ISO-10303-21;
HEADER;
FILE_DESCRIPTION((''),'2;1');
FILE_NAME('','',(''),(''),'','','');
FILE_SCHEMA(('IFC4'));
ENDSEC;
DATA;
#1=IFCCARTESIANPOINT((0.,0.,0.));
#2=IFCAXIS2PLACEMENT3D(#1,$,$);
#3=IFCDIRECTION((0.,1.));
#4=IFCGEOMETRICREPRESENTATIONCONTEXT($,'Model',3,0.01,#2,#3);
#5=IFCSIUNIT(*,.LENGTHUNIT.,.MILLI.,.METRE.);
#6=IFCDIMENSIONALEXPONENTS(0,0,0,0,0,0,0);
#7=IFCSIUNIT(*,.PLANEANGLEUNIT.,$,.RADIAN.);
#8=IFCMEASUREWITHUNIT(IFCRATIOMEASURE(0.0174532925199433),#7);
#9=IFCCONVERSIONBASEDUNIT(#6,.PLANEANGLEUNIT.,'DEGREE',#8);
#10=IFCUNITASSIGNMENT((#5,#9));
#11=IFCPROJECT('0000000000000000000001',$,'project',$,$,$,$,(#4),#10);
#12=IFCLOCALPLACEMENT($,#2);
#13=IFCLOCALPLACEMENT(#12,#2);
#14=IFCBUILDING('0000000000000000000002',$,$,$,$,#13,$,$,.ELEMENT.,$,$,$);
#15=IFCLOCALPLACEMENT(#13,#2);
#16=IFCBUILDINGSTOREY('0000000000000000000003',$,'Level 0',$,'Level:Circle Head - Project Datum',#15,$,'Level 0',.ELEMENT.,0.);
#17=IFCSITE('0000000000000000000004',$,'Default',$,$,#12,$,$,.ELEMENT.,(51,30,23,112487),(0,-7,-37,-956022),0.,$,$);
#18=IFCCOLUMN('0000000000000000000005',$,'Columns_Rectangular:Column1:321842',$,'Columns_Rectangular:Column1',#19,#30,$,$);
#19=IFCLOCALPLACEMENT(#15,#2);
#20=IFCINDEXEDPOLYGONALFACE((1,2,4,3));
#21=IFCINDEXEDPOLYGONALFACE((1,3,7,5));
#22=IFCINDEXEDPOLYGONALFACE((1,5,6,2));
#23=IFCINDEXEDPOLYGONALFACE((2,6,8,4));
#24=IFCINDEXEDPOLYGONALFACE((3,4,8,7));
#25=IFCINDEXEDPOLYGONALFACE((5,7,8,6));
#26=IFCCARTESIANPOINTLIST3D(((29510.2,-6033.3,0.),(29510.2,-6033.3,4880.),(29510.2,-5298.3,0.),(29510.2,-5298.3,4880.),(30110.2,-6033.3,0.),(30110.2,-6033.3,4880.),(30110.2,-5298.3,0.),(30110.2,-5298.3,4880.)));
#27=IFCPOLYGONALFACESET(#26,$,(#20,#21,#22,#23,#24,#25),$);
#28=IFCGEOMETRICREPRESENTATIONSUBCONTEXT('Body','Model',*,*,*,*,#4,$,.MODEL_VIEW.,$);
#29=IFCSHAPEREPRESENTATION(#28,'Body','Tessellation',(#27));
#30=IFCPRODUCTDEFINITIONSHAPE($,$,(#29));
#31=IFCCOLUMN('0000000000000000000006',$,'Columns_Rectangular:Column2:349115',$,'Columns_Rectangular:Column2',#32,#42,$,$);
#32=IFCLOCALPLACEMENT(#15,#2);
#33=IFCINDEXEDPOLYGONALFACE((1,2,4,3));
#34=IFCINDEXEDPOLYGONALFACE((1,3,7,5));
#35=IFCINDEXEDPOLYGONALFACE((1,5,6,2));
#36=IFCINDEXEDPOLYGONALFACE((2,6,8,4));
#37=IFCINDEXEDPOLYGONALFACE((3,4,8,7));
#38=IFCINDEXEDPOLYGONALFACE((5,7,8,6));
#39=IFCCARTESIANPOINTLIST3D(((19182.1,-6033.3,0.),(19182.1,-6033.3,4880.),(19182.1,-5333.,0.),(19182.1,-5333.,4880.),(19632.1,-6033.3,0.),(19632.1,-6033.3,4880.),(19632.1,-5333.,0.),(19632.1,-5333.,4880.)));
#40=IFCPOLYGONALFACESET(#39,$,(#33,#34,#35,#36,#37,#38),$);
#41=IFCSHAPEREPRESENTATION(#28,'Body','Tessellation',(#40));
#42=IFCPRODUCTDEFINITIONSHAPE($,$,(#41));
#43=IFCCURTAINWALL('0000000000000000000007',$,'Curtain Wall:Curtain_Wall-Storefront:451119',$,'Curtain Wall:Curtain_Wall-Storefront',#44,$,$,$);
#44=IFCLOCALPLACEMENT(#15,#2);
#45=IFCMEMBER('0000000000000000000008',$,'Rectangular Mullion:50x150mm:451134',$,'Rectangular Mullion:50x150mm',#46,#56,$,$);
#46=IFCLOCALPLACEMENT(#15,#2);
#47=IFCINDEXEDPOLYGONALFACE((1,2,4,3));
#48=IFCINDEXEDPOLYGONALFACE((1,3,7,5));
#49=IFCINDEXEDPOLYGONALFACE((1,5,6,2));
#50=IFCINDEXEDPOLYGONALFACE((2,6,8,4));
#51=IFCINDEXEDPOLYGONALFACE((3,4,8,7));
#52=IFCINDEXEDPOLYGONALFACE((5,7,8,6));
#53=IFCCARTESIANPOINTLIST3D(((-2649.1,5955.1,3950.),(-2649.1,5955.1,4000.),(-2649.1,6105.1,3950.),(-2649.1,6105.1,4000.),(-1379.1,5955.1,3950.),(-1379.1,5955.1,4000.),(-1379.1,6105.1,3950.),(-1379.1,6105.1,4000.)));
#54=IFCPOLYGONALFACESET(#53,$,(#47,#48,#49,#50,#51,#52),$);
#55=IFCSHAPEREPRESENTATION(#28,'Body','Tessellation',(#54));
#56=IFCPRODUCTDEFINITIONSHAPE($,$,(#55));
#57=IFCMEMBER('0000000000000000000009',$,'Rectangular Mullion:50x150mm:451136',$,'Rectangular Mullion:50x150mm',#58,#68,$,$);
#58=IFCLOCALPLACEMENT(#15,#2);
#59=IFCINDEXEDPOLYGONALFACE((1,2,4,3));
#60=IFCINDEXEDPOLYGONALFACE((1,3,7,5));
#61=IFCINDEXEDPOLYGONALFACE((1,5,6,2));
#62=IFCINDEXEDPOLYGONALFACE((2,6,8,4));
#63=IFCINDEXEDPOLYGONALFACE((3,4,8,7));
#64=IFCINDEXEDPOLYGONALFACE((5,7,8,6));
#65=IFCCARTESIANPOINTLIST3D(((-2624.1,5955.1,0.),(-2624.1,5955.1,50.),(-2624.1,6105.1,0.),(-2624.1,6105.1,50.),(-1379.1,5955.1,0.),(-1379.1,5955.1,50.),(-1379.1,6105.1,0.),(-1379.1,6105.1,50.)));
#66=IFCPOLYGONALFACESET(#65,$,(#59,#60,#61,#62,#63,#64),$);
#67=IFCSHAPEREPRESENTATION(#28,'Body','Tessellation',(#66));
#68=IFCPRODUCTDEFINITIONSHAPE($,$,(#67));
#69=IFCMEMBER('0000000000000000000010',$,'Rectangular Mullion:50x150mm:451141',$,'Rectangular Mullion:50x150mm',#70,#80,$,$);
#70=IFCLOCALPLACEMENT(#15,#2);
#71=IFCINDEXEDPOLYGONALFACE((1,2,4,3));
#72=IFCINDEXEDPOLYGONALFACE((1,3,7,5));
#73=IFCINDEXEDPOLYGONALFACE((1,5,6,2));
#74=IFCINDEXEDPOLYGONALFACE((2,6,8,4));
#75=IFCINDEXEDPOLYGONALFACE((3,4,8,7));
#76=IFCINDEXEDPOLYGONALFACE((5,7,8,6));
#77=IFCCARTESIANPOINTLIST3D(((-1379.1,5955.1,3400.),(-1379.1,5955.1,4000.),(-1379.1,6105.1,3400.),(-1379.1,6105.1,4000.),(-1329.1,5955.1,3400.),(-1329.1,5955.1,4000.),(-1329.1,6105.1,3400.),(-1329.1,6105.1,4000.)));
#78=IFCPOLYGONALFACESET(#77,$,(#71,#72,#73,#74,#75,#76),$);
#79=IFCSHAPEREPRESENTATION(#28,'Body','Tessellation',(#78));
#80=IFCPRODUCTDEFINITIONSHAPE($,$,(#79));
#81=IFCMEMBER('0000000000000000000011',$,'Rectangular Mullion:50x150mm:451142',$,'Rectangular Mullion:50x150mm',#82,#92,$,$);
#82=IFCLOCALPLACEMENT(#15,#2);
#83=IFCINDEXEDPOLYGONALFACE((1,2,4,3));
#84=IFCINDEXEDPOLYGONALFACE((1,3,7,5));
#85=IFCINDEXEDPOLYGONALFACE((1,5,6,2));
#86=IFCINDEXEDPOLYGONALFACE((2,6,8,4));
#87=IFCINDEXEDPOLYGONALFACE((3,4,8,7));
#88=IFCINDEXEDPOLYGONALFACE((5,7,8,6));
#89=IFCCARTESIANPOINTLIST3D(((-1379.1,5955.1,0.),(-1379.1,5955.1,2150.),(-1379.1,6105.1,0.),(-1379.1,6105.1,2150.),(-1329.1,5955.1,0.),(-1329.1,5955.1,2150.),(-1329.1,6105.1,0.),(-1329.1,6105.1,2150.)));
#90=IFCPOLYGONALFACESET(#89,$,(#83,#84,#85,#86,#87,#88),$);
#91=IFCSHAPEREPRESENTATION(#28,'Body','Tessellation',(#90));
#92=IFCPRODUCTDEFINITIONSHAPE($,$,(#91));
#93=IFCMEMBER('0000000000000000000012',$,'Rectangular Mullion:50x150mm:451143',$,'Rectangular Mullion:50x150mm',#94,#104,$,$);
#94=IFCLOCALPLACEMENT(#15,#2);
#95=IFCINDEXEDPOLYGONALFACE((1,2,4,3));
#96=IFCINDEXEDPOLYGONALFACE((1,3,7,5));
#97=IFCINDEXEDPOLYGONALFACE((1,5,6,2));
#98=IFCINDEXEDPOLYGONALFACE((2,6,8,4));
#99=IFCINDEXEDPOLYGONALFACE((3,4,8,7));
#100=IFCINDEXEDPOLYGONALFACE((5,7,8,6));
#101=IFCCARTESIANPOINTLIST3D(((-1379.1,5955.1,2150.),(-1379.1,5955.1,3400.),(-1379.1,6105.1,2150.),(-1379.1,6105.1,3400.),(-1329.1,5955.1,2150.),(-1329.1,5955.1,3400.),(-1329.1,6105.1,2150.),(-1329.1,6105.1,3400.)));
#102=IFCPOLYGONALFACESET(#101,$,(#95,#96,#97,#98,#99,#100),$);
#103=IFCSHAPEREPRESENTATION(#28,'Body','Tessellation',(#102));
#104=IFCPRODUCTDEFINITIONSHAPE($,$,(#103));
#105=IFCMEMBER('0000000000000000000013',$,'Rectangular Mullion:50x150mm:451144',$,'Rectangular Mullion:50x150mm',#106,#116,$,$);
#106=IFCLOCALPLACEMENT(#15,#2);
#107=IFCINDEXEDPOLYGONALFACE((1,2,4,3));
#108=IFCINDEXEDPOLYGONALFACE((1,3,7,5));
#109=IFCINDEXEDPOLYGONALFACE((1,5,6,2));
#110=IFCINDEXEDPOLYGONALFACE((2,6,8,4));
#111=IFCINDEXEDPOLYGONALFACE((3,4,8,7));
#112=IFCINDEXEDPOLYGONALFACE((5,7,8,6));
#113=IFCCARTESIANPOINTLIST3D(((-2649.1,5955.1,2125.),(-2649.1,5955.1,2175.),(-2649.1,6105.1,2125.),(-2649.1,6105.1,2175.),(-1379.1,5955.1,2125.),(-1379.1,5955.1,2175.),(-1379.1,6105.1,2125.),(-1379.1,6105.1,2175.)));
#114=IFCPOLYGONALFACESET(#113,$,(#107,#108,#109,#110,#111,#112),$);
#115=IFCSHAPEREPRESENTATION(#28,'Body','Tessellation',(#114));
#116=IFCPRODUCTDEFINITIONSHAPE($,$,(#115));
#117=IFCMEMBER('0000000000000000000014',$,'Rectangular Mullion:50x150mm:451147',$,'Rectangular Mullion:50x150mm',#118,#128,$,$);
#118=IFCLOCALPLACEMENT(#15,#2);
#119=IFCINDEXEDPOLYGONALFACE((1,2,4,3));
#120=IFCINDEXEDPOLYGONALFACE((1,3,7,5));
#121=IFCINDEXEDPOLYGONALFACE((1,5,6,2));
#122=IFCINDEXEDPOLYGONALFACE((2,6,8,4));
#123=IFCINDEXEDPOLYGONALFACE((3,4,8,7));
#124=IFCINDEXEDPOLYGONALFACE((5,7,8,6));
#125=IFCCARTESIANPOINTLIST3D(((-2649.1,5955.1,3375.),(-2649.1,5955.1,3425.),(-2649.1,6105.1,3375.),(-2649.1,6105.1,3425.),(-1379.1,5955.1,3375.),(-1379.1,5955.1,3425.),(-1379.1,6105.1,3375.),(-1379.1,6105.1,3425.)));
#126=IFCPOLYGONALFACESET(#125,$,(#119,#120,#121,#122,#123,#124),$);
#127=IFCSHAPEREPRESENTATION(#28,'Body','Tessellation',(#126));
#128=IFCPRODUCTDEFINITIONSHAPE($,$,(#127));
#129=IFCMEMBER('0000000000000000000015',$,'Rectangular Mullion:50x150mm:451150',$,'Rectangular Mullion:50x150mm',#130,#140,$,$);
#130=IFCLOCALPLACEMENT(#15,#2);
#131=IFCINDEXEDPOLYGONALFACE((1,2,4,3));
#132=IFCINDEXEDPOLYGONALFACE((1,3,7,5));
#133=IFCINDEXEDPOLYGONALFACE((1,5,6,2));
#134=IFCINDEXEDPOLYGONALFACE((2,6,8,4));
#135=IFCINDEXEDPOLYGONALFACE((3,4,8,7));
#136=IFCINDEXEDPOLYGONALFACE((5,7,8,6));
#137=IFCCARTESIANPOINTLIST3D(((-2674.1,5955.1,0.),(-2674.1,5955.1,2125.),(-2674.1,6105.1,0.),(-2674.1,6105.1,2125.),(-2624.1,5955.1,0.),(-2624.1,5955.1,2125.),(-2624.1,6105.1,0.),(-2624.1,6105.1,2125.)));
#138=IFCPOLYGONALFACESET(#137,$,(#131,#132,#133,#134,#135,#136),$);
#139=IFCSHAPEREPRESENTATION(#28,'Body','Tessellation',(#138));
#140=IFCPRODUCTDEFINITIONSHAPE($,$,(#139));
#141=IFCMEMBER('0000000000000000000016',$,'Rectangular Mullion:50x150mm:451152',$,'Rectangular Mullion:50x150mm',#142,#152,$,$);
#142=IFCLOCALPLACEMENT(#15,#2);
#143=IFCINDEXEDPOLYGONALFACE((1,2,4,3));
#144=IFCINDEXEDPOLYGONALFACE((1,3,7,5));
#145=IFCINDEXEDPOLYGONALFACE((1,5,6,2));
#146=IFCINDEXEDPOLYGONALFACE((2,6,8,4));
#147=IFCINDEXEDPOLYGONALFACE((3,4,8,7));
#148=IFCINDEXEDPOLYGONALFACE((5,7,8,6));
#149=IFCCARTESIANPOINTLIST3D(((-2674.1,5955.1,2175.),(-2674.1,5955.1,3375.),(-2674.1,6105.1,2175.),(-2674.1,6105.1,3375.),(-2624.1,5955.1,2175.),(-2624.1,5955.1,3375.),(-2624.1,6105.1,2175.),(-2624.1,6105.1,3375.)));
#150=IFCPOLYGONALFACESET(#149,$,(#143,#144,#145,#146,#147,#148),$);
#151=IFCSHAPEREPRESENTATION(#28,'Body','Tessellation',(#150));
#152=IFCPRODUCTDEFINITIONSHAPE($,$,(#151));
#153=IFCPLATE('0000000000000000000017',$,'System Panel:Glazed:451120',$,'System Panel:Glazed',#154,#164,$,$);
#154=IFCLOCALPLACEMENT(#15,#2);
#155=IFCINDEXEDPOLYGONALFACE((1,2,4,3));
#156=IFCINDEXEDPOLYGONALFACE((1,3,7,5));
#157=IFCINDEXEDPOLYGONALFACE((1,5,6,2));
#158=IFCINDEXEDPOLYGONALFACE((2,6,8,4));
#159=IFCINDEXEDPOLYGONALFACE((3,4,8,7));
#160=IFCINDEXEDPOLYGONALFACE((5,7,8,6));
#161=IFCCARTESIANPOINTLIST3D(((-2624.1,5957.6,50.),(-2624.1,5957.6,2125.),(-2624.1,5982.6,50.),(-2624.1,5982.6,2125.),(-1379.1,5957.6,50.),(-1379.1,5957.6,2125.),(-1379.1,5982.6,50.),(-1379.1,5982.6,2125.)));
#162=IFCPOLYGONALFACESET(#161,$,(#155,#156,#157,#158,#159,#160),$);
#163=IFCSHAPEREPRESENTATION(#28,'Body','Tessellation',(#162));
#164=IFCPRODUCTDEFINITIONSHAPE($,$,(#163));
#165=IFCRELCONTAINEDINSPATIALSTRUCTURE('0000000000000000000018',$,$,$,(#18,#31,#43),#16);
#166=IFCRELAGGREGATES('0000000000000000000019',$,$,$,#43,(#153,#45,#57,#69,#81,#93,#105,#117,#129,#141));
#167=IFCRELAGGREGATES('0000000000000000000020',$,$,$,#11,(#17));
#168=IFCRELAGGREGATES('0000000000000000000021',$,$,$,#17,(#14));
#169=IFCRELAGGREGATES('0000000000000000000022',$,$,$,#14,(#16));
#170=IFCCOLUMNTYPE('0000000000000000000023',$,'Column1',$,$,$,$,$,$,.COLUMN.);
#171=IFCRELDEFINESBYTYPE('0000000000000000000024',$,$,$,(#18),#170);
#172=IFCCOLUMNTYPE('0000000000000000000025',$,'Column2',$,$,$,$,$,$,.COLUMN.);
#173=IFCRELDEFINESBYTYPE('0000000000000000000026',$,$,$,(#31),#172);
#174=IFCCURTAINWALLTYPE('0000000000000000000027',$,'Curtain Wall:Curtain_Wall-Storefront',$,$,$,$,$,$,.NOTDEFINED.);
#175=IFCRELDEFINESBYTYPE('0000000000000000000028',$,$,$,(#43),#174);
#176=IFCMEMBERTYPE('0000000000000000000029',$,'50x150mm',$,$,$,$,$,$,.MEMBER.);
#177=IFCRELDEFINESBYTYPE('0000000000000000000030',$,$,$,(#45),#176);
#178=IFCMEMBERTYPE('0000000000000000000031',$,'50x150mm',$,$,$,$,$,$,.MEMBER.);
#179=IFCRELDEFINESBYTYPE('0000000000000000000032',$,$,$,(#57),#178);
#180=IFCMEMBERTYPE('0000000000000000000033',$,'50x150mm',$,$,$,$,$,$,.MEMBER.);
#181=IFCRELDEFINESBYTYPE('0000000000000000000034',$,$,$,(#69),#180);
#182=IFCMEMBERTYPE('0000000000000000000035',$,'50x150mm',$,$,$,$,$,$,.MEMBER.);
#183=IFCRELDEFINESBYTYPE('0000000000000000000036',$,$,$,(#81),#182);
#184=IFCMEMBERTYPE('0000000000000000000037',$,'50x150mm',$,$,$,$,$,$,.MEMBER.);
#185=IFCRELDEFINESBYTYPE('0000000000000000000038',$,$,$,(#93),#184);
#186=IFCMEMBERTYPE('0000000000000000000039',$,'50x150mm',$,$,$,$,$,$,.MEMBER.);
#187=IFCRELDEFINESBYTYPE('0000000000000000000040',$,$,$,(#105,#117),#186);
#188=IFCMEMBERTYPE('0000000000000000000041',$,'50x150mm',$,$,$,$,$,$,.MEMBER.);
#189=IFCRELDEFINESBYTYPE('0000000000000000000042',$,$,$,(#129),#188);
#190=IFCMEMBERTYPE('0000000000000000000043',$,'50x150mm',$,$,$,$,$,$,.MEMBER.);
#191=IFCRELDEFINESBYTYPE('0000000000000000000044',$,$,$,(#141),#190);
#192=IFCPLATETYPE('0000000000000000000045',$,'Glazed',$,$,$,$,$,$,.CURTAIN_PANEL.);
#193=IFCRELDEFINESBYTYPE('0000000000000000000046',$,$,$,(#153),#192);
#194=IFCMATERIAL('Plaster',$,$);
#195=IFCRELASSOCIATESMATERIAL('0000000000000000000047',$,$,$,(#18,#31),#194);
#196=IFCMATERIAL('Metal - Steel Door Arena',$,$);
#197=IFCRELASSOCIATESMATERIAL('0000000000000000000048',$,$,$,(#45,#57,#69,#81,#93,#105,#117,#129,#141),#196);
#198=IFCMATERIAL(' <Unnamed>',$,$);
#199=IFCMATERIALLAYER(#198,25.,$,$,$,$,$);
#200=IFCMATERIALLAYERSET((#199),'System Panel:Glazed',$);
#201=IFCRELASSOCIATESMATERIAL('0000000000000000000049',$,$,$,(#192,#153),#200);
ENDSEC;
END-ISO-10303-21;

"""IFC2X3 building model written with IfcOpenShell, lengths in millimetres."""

from ifc_helpers import new_model, entity, si_unit, converted_unit, direction, frame, frame_2d, origin, origin_2d_with_axis, place, context, subcontext, project, spatial, rectangle, extrude, source, transform, mapped, material, layer, layer_set, layer_usage, type_object, type_shapes, element, aggregate, save


model = new_model("IFC2X3")

# Units and contexts
model_context = context("Model", 3, precision=0.01, world=origin(), true_north=direction((0.0, 1.0)))
body_context = subcontext(model_context, "Body", "Model", "MODEL_VIEW")
ifc_project = project(units=[si_unit("LENGTHUNIT", "METRE", prefix="MILLI"), converted_unit("PLANEANGLEUNIT", "DEGREE", entity("IfcRatioMeasure", 0.0174532925199433), si_unit("PLANEANGLEUNIT", "RADIAN"), dimensions=[0, 0, 0, 0, 0, 0, 0])], contexts=[model_context])

# Site, building, storey
site_placement = place(None, origin())
site = spatial("IfcSite", under=ifc_project, at=site_placement, Name="Default", CompositionType="ELEMENT", RefLatitude=(51, 30, 23, 112487), RefLongitude=(0, -7, -37, -956022), RefElevation=0.0)
building_placement = place(site_placement, origin())
building = spatial("IfcBuilding", under=site, at=building_placement, CompositionType="ELEMENT")
storey_placement = place(building_placement, origin())
storey = spatial("IfcBuildingStorey", under=building, at=storey_placement, Name="Level 0", ObjectType="Level:Circle Head - Project Datum", LongName="Level 0", CompositionType="ELEMENT", Elevation=0.0)

# Columns
ifc_material_1 = material(Name="Plaster")
column_type_1 = type_object("IfcColumnType", Name="Column1", PredefinedType="COLUMN")
shared_shape_1 = source(origin(), body_context, "Body", "SweptSolid", [
    extrude(rectangle(XDim=735.0, YDim=600.0, at=frame_2d((0.0, 0.0), x_axis=(1.0, 0.0))), frame((29810.2, -5665.8, 0.0), z_axis=(0.0, 0.0, 1.0), x_axis=(0.0, -1.0, 0.0)), (0.0, 0.0, 1.0), 4880.0),
])
type_shapes(column_type_1, [shared_shape_1])
column_1_placement = place(storey_placement, origin())
element("IfcColumn", 1, at=column_1_placement, inside=storey, type_object=column_type_1, material=ifc_material_1, Name="Columns_Rectangular:Column1:321842", ObjectType="Columns_Rectangular:Column1", context=body_context, shape_type="MappedRepresentation", body=[
    mapped(shared_shape_1, transform((0.0, 0.0, 0.0), scale=1.0)),
])
column_type_2 = type_object("IfcColumnType", Name="Column2", PredefinedType="COLUMN")
shared_shape_2 = source(origin(), body_context, "Body", "SweptSolid", [
    extrude(rectangle(XDim=700.3, YDim=450.0, at=frame_2d((0.0, 0.0), x_axis=(1.0, 0.0))), frame((19407.1, -5683.1, 0.0), z_axis=(0.0, 0.0, 1.0), x_axis=(0.0, -1.0, 0.0)), (0.0, 0.0, 1.0), 4880.0),
])
type_shapes(column_type_2, [shared_shape_2])
column_2_placement = place(storey_placement, origin())
element("IfcColumn", 2, at=column_2_placement, inside=storey, type_object=column_type_2, material=ifc_material_1, Name="Columns_Rectangular:Column2:349115", ObjectType="Columns_Rectangular:Column2", context=body_context, shape_type="MappedRepresentation", body=[
    mapped(shared_shape_2, transform((0.0, 0.0, 0.0), scale=1.0)),
])

# Curtain wall, members
curtain_wall_type = type_object("IfcCurtainWallType", Name="Curtain Wall:Curtain_Wall-Storefront", PredefinedType="NOTDEFINED")
curtain_wall_1_placement = place(storey_placement, origin())
curtain_wall_1 = element("IfcCurtainWall", 3, at=curtain_wall_1_placement, inside=storey, type_object=curtain_wall_type, Name="Curtain Wall:Curtain_Wall-Storefront:451119", ObjectType="Curtain Wall:Curtain_Wall-Storefront")
ifc_material_2 = material(Name="Metal - Steel Door Arena")
member_type_1 = type_object("IfcMemberType", Name="50x150mm", PredefinedType="MEMBER")
shared_shape_3 = source(origin(), body_context, "Body", "SweptSolid", [
    extrude(rectangle(XDim=150.0, YDim=50.0, at=origin_2d_with_axis()), frame((-25.0, 0.0, -1270.0), z_axis=(0.0, 0.0, 1.0), x_axis=(0.0, -1.0, 0.0)), (0.0, 0.0, 1.0), 1270.0),
])
type_shapes(member_type_1, [shared_shape_3])
member_1_placement = place(storey_placement, frame((-2649.1, 6030.1, 4000.0), z_axis=(-1.0, 0.0, 0.0), x_axis=(0.0, 0.0, 1.0)))
member_1 = element("IfcMember", 4, at=member_1_placement, type_object=member_type_1, material=ifc_material_2, Name="Rectangular Mullion:50x150mm:451134", ObjectType="Rectangular Mullion:50x150mm", context=body_context, shape_type="MappedRepresentation", body=[
    mapped(shared_shape_3, transform((0.0, 0.0, 0.0), scale=1.0)),
])
member_type_2 = type_object("IfcMemberType", Name="50x150mm", PredefinedType="MEMBER")
shared_shape_4 = source(origin(), body_context, "Body", "SweptSolid", [
    extrude(rectangle(XDim=150.0, YDim=50.0, at=origin_2d_with_axis()), frame((-25.0, 0.0, -1245.0), z_axis=(0.0, 0.0, 1.0), x_axis=(0.0, -1.0, 0.0)), (0.0, 0.0, 1.0), 1245.0),
])
type_shapes(member_type_2, [shared_shape_4])
member_2_placement = place(storey_placement, frame((-1379.1, 6030.1, 0.0), z_axis=(1.0, 0.0, 0.0), x_axis=(0.0, 0.0, -1.0)))
member_2 = element("IfcMember", 5, at=member_2_placement, type_object=member_type_2, material=ifc_material_2, Name="Rectangular Mullion:50x150mm:451136", ObjectType="Rectangular Mullion:50x150mm", context=body_context, shape_type="MappedRepresentation", body=[
    mapped(shared_shape_4, transform((0.0, 0.0, 0.0), scale=1.0)),
])
member_type_3 = type_object("IfcMemberType", Name="50x150mm", PredefinedType="MEMBER")
shared_shape_5 = source(origin(), body_context, "Body", "SweptSolid", [
    extrude(rectangle(XDim=150.0, YDim=50.0, at=origin_2d_with_axis()), frame((-25.0, 0.0, -600.0), z_axis=(0.0, 0.0, 1.0), x_axis=(0.0, -1.0, 0.0)), (0.0, 0.0, 1.0), 600.0),
])
type_shapes(member_type_3, [shared_shape_5])
member_3_placement = place(storey_placement, frame((-1329.1, 6030.1, 4000.0)))
member_3 = element("IfcMember", 6, at=member_3_placement, type_object=member_type_3, material=ifc_material_2, Name="Rectangular Mullion:50x150mm:451141", ObjectType="Rectangular Mullion:50x150mm", context=body_context, shape_type="MappedRepresentation", body=[
    mapped(shared_shape_5, transform((0.0, 0.0, 0.0), scale=1.0)),
])
member_type_4 = type_object("IfcMemberType", Name="50x150mm", PredefinedType="MEMBER")
shared_shape_6 = source(origin(), body_context, "Body", "SweptSolid", [
    extrude(rectangle(XDim=150.0, YDim=50.0, at=origin_2d_with_axis()), frame((-25.0, 0.0, -2150.0), z_axis=(0.0, 0.0, 1.0), x_axis=(0.0, -1.0, 0.0)), (0.0, 0.0, 1.0), 2150.0),
])
type_shapes(member_type_4, [shared_shape_6])
member_4_placement = place(storey_placement, frame((-1329.1, 6030.1, 2150.0)))
member_4 = element("IfcMember", 7, at=member_4_placement, type_object=member_type_4, material=ifc_material_2, Name="Rectangular Mullion:50x150mm:451142", ObjectType="Rectangular Mullion:50x150mm", context=body_context, shape_type="MappedRepresentation", body=[
    mapped(shared_shape_6, transform((0.0, 0.0, 0.0), scale=1.0)),
])
member_type_5 = type_object("IfcMemberType", Name="50x150mm", PredefinedType="MEMBER")
shared_shape_7 = source(origin(), body_context, "Body", "SweptSolid", [
    extrude(rectangle(XDim=150.0, YDim=50.0, at=origin_2d_with_axis()), frame((-25.0, 0.0, -1250.0), z_axis=(0.0, 0.0, 1.0), x_axis=(0.0, -1.0, 0.0)), (0.0, 0.0, 1.0), 1250.0),
])
type_shapes(member_type_5, [shared_shape_7])
member_5_placement = place(storey_placement, frame((-1329.1, 6030.1, 3400.0)))
member_5 = element("IfcMember", 8, at=member_5_placement, type_object=member_type_5, material=ifc_material_2, Name="Rectangular Mullion:50x150mm:451143", ObjectType="Rectangular Mullion:50x150mm", context=body_context, shape_type="MappedRepresentation", body=[
    mapped(shared_shape_7, transform((0.0, 0.0, 0.0), scale=1.0)),
])
member_type_6 = type_object("IfcMemberType", Name="50x150mm", PredefinedType="MEMBER")
shared_shape_8 = source(origin(), body_context, "Body", "SweptSolid", [
    extrude(rectangle(XDim=150.0, YDim=50.0, at=origin_2d_with_axis()), frame((0.0, 0.0, -1270.0), z_axis=(0.0, 0.0, 1.0), x_axis=(0.0, -1.0, 0.0)), (0.0, 0.0, 1.0), 1270.0),
])
type_shapes(member_type_6, [shared_shape_8])
member_6_placement = place(storey_placement, frame((-2649.1, 6030.1, 2150.0), z_axis=(-1.0, 0.0, 0.0), x_axis=(0.0, 0.0, 1.0)))
member_6 = element("IfcMember", 9, at=member_6_placement, type_object=member_type_6, material=ifc_material_2, Name="Rectangular Mullion:50x150mm:451144", ObjectType="Rectangular Mullion:50x150mm", context=body_context, shape_type="MappedRepresentation", body=[
    mapped(shared_shape_8, transform((0.0, 0.0, 0.0), scale=1.0)),
])
member_7_placement = place(storey_placement, frame((-2649.1, 6030.1, 3400.0), z_axis=(-1.0, 0.0, 0.0), x_axis=(0.0, 0.0, 1.0)))
member_7 = element("IfcMember", 10, at=member_7_placement, type_object=member_type_6, material=ifc_material_2, Name="Rectangular Mullion:50x150mm:451147", ObjectType="Rectangular Mullion:50x150mm", context=body_context, shape_type="MappedRepresentation", body=[
    mapped(shared_shape_8, transform((0.0, 0.0, 0.0), scale=1.0)),
])
member_type_7 = type_object("IfcMemberType", Name="50x150mm", PredefinedType="MEMBER")
shared_shape_9 = source(origin(), body_context, "Body", "SweptSolid", [
    extrude(rectangle(XDim=150.0, YDim=50.0, at=origin_2d_with_axis()), frame((0.0, 0.0, -2125.0), z_axis=(0.0, 0.0, 1.0), x_axis=(0.0, -1.0, 0.0)), (0.0, 0.0, 1.0), 2125.0),
])
type_shapes(member_type_7, [shared_shape_9])
member_8_placement = place(storey_placement, frame((-2649.1, 6030.1, 0.0), z_axis=(0.0, 0.0, -1.0), x_axis=(-1.0, 0.0, 0.0)))
member_8 = element("IfcMember", 11, at=member_8_placement, type_object=member_type_7, material=ifc_material_2, Name="Rectangular Mullion:50x150mm:451150", ObjectType="Rectangular Mullion:50x150mm", context=body_context, shape_type="MappedRepresentation", body=[
    mapped(shared_shape_9, transform((0.0, 0.0, 0.0), scale=1.0)),
])
member_type_8 = type_object("IfcMemberType", Name="50x150mm", PredefinedType="MEMBER")
shared_shape_10 = source(origin(), body_context, "Body", "SweptSolid", [
    extrude(rectangle(XDim=150.0, YDim=50.0, at=origin_2d_with_axis()), frame((0.0, 0.0, -1200.0), z_axis=(0.0, 0.0, 1.0), x_axis=(0.0, -1.0, 0.0)), (0.0, 0.0, 1.0), 1200.0),
])
type_shapes(member_type_8, [shared_shape_10])
member_9_placement = place(storey_placement, frame((-2649.1, 6030.1, 2175.0), z_axis=(0.0, 0.0, -1.0), x_axis=(-1.0, 0.0, 0.0)))
member_9 = element("IfcMember", 12, at=member_9_placement, type_object=member_type_8, material=ifc_material_2, Name="Rectangular Mullion:50x150mm:451152", ObjectType="Rectangular Mullion:50x150mm", context=body_context, shape_type="MappedRepresentation", body=[
    mapped(shared_shape_10, transform((0.0, 0.0, 0.0), scale=1.0)),
])

# Plate
ifc_material_3 = material(Name=" <Unnamed>")
ifc_layer_1 = layer(ifc_material_3, 25.0)
ifc_layer_set_1 = layer_set([ifc_layer_1], Name="System Panel:Glazed")
ifc_layer_usage_1 = layer_usage(ifc_layer_set_1, "AXIS3", "POSITIVE", 0.2)
plate_type_1 = type_object("IfcPlateType", Name="Glazed", PredefinedType="CURTAIN_PANEL", material=ifc_layer_set_1)
shared_shape_11 = source(origin(), body_context, "Body", "SweptSolid", [
    extrude(rectangle(XDim=25.0, YDim=1245.0, at=origin_2d_with_axis()), frame((0.0, 60.0, 0.0), z_axis=(0.0, 0.0, 1.0), x_axis=(0.0, 1.0, 0.0)), (0.0, 0.0, 1.0), 2075.0),
])
type_shapes(plate_type_1, [shared_shape_11])
plate_1_placement = place(curtain_wall_1_placement, frame((-2001.6, 6030.1, 50.0), z_axis=(0.0, 0.0, 1.0), x_axis=(-1.0, 0.0, 0.0)))
plate_1 = element("IfcPlate", 13, at=plate_1_placement, type_object=plate_type_1, material=ifc_layer_usage_1, Name="System Panel:Glazed:451120", ObjectType="System Panel:Glazed", context=body_context, shape_type="MappedRepresentation", body=[
    mapped(shared_shape_11, transform((0.0, 0.0, 0.0), scale=1.0)),
])
aggregate(curtain_wall_1, [plate_1, member_1, member_2, member_3, member_4, member_5, member_6, member_7, member_8, member_9])

save(model, "model.ifc")
